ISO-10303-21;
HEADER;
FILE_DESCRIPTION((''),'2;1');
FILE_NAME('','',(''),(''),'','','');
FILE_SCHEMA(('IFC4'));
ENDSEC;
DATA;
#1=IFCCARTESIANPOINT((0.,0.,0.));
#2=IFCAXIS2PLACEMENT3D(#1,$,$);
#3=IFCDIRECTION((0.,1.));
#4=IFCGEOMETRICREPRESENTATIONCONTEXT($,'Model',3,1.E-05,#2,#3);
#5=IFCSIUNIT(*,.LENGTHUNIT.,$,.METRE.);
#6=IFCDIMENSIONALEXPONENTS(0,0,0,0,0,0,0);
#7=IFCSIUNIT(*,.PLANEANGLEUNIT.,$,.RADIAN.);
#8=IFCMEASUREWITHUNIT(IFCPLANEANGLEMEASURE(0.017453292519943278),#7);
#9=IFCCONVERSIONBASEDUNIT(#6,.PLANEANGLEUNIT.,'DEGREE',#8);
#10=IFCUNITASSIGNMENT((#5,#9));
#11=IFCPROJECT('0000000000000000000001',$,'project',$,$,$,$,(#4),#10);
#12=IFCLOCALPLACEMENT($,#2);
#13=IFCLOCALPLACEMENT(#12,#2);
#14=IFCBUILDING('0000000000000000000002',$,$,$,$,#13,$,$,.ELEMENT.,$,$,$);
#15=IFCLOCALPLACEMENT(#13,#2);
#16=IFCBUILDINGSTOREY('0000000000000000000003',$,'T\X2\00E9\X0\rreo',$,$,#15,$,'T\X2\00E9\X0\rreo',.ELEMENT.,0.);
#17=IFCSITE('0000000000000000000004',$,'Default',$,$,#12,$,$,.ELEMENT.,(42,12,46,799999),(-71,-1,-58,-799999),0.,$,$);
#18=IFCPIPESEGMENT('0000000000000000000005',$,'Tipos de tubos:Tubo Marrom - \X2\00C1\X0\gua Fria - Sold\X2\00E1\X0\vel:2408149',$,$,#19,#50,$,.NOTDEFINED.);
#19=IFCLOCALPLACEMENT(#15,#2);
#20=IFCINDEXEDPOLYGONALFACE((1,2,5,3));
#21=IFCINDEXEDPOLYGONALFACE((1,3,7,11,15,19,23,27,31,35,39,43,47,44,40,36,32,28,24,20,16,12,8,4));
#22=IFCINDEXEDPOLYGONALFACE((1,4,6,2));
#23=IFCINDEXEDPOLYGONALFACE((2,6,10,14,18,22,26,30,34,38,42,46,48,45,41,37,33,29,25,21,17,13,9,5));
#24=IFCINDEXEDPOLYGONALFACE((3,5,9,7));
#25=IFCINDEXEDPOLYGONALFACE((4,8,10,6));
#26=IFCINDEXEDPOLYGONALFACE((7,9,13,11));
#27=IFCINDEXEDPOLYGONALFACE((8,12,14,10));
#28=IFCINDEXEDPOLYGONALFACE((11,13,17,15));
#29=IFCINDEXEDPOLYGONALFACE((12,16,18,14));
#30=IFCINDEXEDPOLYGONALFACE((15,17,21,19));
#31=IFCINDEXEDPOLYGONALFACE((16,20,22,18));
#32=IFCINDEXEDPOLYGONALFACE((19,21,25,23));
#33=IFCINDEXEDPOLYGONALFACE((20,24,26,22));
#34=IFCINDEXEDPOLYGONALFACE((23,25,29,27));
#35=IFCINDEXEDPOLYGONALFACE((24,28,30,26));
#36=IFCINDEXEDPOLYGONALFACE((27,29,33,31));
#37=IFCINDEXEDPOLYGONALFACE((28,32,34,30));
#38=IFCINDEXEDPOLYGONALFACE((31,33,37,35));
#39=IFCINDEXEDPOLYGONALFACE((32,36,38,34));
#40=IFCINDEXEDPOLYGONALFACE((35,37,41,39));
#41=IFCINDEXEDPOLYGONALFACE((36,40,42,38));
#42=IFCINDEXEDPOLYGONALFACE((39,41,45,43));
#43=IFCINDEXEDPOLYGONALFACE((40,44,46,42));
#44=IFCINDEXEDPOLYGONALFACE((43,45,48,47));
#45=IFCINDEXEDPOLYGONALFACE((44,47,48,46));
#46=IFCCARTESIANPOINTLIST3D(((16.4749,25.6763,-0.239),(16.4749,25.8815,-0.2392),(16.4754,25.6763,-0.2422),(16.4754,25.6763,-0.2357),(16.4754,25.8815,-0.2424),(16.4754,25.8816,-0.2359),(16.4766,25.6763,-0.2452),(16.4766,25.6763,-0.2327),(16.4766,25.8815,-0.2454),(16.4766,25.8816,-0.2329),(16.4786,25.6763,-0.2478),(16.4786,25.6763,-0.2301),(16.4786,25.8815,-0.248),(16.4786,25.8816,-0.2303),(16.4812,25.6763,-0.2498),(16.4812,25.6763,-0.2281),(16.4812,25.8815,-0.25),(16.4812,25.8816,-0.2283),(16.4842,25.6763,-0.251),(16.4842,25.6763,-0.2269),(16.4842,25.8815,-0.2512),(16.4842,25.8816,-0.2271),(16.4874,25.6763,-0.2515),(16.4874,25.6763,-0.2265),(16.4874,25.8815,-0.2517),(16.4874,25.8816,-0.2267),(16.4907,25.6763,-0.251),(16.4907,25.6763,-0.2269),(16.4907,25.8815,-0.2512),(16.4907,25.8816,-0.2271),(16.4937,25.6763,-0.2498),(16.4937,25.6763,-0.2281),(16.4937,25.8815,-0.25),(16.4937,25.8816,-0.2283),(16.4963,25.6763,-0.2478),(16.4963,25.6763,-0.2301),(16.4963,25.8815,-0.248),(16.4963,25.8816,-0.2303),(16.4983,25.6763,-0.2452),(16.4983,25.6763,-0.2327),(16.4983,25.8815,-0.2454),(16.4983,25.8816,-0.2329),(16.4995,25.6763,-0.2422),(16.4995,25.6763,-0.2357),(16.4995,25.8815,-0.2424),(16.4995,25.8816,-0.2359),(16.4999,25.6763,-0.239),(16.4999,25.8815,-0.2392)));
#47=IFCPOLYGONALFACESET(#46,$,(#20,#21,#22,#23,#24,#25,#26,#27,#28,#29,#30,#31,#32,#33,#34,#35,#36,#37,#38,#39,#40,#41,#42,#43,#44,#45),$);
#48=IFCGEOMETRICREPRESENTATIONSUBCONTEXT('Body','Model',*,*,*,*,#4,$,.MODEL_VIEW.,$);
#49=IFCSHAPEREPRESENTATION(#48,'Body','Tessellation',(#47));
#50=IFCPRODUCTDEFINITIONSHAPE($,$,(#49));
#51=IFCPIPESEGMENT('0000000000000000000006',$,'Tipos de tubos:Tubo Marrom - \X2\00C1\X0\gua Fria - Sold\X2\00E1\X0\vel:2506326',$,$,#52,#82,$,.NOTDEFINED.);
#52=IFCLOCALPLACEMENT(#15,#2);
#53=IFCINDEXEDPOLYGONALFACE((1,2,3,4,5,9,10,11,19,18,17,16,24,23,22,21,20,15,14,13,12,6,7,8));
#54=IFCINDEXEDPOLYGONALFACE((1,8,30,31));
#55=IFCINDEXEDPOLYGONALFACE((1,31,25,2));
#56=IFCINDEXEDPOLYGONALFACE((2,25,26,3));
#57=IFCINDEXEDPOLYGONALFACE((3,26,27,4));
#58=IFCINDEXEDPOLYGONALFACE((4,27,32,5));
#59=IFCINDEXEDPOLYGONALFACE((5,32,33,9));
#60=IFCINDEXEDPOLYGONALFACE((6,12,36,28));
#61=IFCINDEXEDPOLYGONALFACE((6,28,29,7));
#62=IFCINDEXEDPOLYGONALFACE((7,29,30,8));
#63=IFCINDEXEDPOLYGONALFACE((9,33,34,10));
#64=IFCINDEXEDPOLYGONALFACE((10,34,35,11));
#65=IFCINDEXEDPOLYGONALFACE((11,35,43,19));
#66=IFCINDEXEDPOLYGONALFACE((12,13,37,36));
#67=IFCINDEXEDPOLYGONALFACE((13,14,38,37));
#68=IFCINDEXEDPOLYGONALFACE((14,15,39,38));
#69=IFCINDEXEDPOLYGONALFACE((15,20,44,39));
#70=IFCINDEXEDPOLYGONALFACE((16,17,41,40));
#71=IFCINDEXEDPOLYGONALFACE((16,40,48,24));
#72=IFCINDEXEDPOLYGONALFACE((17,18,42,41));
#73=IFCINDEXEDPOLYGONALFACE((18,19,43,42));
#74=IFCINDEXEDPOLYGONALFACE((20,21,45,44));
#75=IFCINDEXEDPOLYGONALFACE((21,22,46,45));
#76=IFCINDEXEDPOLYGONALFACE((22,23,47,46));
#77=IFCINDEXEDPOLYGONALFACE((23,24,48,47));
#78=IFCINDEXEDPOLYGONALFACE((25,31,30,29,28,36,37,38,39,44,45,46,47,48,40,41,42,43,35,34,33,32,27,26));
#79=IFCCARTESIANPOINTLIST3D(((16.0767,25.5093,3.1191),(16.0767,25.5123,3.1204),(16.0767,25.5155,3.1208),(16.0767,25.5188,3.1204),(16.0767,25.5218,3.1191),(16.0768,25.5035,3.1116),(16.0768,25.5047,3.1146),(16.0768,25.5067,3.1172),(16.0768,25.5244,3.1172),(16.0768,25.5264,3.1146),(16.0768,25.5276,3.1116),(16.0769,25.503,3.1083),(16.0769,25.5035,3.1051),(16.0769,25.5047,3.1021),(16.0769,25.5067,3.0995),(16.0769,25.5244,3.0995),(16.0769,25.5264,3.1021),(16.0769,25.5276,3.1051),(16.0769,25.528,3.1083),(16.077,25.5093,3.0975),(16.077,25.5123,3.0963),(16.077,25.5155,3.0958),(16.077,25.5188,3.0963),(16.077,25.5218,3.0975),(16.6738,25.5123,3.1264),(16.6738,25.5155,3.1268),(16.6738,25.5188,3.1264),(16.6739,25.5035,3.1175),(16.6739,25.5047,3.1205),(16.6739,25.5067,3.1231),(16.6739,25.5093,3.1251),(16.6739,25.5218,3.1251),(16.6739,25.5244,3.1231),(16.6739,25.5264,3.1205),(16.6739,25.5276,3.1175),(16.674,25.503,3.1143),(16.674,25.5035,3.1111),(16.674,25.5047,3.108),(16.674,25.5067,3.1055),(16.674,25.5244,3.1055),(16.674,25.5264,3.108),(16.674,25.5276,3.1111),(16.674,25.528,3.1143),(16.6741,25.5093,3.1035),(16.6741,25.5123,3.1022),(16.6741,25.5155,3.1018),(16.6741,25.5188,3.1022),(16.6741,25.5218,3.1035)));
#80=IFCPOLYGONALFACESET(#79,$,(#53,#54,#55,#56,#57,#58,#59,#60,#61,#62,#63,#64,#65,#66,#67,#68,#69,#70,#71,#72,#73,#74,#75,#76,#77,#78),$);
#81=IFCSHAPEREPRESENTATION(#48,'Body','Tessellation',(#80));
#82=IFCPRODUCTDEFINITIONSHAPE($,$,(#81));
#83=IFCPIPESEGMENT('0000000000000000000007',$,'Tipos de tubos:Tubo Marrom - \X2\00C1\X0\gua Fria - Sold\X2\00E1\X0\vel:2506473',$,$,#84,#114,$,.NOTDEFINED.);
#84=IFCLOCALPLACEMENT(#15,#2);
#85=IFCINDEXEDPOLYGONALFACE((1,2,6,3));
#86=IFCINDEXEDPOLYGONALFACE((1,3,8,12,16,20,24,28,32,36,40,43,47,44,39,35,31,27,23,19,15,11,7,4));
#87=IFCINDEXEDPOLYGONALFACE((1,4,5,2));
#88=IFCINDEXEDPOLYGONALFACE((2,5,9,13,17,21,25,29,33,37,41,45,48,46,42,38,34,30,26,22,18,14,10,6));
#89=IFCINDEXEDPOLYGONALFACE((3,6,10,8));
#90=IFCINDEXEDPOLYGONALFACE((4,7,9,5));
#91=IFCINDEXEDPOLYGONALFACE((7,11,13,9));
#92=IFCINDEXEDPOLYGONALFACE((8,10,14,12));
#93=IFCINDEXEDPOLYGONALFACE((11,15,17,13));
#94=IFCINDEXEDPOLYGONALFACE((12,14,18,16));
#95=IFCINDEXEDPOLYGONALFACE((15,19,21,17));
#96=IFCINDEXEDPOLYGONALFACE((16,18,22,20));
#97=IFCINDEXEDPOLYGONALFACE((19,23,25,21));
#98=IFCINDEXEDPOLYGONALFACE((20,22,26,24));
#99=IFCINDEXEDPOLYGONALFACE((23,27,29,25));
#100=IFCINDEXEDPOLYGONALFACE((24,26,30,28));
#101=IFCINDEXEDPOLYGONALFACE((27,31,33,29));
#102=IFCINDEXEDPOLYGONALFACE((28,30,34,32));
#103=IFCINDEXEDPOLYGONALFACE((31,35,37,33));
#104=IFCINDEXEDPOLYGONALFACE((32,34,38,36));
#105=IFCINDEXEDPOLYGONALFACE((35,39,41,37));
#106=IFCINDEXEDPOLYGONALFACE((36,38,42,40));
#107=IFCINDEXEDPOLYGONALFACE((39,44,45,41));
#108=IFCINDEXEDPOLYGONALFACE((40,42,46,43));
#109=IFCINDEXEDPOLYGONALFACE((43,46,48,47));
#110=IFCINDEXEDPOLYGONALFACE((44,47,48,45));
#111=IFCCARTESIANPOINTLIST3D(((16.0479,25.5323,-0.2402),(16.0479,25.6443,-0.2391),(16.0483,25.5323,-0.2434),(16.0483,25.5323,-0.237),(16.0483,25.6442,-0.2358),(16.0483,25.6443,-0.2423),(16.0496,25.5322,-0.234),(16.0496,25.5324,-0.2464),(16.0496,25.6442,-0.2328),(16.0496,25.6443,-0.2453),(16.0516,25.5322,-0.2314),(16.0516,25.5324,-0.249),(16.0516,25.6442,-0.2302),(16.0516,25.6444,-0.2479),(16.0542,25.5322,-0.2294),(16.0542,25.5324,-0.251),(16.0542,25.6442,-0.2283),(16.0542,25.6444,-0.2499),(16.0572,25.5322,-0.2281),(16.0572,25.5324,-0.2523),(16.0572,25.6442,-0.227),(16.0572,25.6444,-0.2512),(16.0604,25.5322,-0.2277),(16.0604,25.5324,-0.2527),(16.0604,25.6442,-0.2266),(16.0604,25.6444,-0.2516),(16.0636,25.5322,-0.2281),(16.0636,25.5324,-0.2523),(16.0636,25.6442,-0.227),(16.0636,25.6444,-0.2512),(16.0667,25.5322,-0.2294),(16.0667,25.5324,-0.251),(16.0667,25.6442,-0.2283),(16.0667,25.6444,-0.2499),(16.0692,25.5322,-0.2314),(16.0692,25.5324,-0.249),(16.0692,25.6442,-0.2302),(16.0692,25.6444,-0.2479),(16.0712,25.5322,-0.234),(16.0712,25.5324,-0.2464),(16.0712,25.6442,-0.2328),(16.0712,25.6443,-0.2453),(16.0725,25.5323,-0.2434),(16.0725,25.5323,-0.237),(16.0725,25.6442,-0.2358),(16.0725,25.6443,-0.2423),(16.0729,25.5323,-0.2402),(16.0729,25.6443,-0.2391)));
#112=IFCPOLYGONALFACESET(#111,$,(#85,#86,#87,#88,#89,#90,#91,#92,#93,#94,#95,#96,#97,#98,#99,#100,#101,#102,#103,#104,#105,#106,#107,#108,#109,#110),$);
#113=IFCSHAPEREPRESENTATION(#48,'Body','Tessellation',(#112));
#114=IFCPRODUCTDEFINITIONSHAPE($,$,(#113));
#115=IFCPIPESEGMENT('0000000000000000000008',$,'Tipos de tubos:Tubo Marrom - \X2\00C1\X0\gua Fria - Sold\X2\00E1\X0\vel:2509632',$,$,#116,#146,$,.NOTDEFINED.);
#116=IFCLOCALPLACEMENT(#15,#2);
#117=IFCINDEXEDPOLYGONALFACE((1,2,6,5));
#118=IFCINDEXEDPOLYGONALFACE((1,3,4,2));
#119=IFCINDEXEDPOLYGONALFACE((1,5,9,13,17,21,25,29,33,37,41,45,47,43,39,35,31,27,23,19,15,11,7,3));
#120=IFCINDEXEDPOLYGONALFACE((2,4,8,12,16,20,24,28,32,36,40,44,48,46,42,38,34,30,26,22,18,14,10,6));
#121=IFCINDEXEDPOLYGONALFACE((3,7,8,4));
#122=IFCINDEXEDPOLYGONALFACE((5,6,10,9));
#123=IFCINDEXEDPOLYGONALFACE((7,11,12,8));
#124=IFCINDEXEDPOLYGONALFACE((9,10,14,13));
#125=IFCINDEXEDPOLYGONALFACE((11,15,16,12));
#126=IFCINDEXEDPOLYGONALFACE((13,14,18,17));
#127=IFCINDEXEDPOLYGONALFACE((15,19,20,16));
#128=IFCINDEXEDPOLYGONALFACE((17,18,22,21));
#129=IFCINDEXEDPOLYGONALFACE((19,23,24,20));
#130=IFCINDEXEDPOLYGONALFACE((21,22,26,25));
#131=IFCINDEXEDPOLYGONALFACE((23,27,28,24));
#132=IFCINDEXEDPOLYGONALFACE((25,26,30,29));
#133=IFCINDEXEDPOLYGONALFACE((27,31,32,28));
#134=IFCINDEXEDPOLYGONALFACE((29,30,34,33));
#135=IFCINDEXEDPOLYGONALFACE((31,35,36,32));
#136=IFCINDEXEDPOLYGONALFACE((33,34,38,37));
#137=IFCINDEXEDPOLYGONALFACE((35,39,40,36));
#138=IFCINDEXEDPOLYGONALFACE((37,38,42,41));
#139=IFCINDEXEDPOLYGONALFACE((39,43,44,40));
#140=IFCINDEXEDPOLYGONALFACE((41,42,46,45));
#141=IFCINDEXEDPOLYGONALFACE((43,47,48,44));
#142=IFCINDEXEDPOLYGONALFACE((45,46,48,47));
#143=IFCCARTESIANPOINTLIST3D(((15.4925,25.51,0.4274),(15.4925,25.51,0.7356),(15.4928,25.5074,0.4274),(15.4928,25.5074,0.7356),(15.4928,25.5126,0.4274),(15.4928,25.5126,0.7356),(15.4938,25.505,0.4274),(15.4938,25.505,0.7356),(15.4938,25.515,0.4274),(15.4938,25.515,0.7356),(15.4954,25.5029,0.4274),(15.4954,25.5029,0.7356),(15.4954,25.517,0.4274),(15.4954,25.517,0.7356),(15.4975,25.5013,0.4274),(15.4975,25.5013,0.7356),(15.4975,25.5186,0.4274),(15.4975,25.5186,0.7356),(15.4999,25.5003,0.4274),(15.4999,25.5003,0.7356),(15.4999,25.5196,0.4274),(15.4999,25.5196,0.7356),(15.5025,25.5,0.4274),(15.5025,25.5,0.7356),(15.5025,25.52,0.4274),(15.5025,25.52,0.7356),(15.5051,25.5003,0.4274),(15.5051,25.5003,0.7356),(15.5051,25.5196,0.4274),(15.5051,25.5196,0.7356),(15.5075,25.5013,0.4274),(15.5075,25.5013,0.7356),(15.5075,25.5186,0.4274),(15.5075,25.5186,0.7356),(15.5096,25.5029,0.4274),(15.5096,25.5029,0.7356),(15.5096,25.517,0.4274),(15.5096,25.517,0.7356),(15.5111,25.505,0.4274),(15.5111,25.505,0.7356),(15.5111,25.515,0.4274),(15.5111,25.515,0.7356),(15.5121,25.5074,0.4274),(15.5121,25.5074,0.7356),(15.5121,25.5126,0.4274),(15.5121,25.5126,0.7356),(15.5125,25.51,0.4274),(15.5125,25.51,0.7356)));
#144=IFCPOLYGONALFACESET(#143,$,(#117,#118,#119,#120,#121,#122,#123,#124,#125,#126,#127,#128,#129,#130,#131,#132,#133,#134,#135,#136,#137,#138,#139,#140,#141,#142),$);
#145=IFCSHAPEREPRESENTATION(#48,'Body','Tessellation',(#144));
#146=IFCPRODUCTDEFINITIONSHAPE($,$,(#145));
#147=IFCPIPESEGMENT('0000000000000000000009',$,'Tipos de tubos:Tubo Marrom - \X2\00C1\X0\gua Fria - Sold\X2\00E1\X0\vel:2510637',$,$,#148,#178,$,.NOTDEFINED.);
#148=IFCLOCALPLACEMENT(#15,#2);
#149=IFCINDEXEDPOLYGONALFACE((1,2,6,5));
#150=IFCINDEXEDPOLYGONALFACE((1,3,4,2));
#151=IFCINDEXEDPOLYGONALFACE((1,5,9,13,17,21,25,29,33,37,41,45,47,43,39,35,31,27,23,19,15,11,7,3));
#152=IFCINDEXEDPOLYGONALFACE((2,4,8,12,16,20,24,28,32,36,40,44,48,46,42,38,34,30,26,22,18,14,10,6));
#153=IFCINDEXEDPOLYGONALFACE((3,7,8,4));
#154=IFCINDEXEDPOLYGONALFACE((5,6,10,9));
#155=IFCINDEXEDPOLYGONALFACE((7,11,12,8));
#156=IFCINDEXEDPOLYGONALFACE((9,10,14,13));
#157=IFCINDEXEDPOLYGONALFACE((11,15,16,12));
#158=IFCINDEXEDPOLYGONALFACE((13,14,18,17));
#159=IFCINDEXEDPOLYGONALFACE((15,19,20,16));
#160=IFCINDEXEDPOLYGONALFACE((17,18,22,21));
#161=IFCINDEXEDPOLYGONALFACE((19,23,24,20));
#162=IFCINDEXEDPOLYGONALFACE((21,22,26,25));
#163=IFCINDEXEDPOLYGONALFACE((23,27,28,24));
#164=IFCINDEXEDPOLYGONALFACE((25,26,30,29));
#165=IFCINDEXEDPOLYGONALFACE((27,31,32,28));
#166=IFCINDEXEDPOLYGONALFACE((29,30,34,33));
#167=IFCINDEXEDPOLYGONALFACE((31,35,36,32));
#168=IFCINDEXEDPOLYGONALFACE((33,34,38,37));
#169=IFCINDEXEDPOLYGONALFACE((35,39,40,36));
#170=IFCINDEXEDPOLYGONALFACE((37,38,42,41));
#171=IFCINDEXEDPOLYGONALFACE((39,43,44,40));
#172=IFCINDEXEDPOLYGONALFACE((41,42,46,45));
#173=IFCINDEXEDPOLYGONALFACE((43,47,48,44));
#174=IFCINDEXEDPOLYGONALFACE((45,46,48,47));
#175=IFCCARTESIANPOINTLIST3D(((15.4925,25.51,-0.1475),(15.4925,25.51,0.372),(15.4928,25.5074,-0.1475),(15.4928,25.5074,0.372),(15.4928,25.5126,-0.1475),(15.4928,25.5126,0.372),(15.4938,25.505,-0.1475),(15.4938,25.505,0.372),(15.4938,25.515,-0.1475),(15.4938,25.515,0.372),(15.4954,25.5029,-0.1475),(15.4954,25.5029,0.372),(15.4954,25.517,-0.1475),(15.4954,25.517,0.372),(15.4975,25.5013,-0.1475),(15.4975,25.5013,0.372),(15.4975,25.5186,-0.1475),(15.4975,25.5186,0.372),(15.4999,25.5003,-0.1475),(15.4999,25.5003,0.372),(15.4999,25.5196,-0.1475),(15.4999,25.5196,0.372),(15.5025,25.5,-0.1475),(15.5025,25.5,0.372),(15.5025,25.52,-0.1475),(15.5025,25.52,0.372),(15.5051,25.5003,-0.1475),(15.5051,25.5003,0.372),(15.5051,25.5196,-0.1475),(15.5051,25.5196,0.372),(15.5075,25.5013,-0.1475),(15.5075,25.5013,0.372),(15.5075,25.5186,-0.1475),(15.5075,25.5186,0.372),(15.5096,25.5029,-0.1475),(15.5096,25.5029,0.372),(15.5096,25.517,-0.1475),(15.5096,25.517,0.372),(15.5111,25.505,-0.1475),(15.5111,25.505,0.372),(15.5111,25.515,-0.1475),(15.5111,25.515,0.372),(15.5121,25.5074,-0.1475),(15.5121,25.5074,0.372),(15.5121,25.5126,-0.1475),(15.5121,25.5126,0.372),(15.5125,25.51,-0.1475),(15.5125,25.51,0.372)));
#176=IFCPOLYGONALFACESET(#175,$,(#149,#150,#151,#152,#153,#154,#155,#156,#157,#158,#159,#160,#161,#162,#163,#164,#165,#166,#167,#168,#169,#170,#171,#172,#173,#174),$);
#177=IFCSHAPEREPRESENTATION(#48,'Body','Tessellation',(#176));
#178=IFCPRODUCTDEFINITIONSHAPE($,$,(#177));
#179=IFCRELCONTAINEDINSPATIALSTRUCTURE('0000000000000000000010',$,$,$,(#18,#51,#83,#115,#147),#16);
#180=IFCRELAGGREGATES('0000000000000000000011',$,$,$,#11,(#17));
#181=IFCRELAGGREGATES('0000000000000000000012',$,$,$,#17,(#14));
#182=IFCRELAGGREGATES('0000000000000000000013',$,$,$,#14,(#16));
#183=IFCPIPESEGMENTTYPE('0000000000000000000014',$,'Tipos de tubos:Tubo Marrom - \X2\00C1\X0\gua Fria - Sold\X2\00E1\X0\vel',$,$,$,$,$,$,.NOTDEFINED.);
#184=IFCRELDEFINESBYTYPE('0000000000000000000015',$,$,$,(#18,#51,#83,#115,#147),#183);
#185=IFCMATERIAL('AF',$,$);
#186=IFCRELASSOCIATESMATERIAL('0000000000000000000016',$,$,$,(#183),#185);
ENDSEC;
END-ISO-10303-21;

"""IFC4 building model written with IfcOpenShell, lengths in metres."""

from ifc_helpers import new_model, entity, si_unit, converted_unit, direction, frame, origin, place, context, subcontext, project, spatial, arc, indexed_curve, outline, extrude, material, type_object, element, save


model = new_model("IFC4")

# Units and contexts
model_context = context("Model", 3, precision=1e-05, world=origin(), true_north=direction((0.0, 1.0)))
body_context = subcontext(model_context, "Body", "Model", "MODEL_VIEW")
ifc_project = project(units=[si_unit("LENGTHUNIT", "METRE"), converted_unit("PLANEANGLEUNIT", "DEGREE", entity("IfcPlaneAngleMeasure", 0.017453292519943278), si_unit("PLANEANGLEUNIT", "RADIAN"), dimensions=[0, 0, 0, 0, 0, 0, 0])], contexts=[model_context])

# Site, building, storey
site_placement = place(None, origin())
site = spatial("IfcSite", under=ifc_project, at=site_placement, Name="Default", CompositionType="ELEMENT", RefLatitude=(42, 12, 46, 799999), RefLongitude=(-71, -1, -58, -799999), RefElevation=0.0)
building_placement = place(site_placement, origin())
building = spatial("IfcBuilding", under=site, at=building_placement, CompositionType="ELEMENT")
storey_placement = place(building_placement, origin())
storey = spatial("IfcBuildingStorey", under=building, at=storey_placement, Name="Térreo", LongName="Térreo", CompositionType="ELEMENT", Elevation=0.0)

# Pipe segments
ifc_material_1 = material(Name="AF")
pipe_segment_type_1 = type_object("IfcPipeSegmentType", Name="Tipos de tubos:Tubo Marrom - Água Fria - Soldável", PredefinedType="NOTDEFINED", material=ifc_material_1)
pipe_segment_1_placement = place(storey_placement, origin())
element("IfcPipeSegment", 1, at=pipe_segment_1_placement, inside=storey, type_object=pipe_segment_type_1, Name="Tipos de tubos:Tubo Marrom - Água Fria - Soldável:2408149", PredefinedType="NOTDEFINED", context=body_context, shape_type="SweptSolid", body=[
    extrude(outline(indexed_curve([(0.0125, 0.0), (0.0088, 0.0088), (0.0, 0.0125), (-0.0088, 0.0088), (-0.0125, 0.0), (-0.0088, -0.0088), (0.0, -0.0125), (0.0088, -0.0088)], segments=[arc(1, 2, 3), arc(3, 4, 5), arc(5, 6, 7), arc(7, 8, 1)], self_intersect=False)), frame((16.4874, 25.8815, -0.2392), z_axis=(0.0, -0.999999, 0.00104), x_axis=(-1.0, 0.0, 0.0)), (0.0, 0.0, 1.0), 0.2053),
])
pipe_segment_2_placement = place(storey_placement, origin())
element("IfcPipeSegment", 2, at=pipe_segment_2_placement, inside=storey, type_object=pipe_segment_type_1, Name="Tipos de tubos:Tubo Marrom - Água Fria - Soldável:2506326", PredefinedType="NOTDEFINED", context=body_context, shape_type="SweptSolid", body=[
    extrude(outline(indexed_curve([(0.0125, 0.0), (0.0088, 0.0088), (0.0, 0.0125), (-0.0088, 0.0088), (-0.0125, 0.0), (-0.0088, -0.0088), (0.0, -0.0125), (0.0088, -0.0088)], segments=[arc(1, 2, 3), arc(3, 4, 5), arc(5, 6, 7), arc(7, 8, 1)], self_intersect=False)), frame((16.0769, 25.5155, 3.1083), z_axis=(0.99995, 0.0, 0.01), x_axis=(0.0, -1.0, 0.0)), (0.0, 0.0, 1.0), 0.5971),
])
pipe_segment_3_placement = place(storey_placement, origin())
element("IfcPipeSegment", 3, at=pipe_segment_3_placement, inside=storey, type_object=pipe_segment_type_1, Name="Tipos de tubos:Tubo Marrom - Água Fria - Soldável:2506473", PredefinedType="NOTDEFINED", context=body_context, shape_type="SweptSolid", body=[
    extrude(outline(indexed_curve([(0.0125, 0.0), (0.0088, 0.0088), (0.0, 0.0125), (-0.0088, 0.0088), (-0.0125, 0.0), (-0.0088, -0.0088), (0.0, -0.0125), (0.0088, -0.0088)], segments=[arc(1, 2, 3), arc(3, 4, 5), arc(5, 6, 7), arc(7, 8, 1)], self_intersect=False)), frame((16.0604, 25.5323, -0.2402), z_axis=(0.0, 0.99995, 0.01), x_axis=(1.0, 0.0, 0.0)), (0.0, 0.0, 1.0), 0.112),
])
pipe_segment_4_placement = place(storey_placement, origin())
element("IfcPipeSegment", 4, at=pipe_segment_4_placement, inside=storey, type_object=pipe_segment_type_1, Name="Tipos de tubos:Tubo Marrom - Água Fria - Soldável:2509632", PredefinedType="NOTDEFINED", context=body_context, shape_type="SweptSolid", body=[
    extrude(outline(indexed_curve([(0.01, 0.0), (0.0071, 0.0071), (0.0, 0.01), (-0.0071, 0.0071), (-0.01, 0.0), (-0.0071, -0.0071), (0.0, -0.01), (0.0071, -0.0071)], segments=[arc(1, 2, 3), arc(3, 4, 5), arc(5, 6, 7), arc(7, 8, 1)], self_intersect=False)), frame((15.5025, 25.51, 0.4274), z_axis=(0.0, 0.0, 1.0), x_axis=(-1.0, 0.0, 0.0)), (0.0, 0.0, 1.0), 0.3082),
])
pipe_segment_5_placement = place(storey_placement, origin())
element("IfcPipeSegment", 5, at=pipe_segment_5_placement, inside=storey, type_object=pipe_segment_type_1, Name="Tipos de tubos:Tubo Marrom - Água Fria - Soldável:2510637", PredefinedType="NOTDEFINED", context=body_context, shape_type="SweptSolid", body=[
    extrude(outline(indexed_curve([(0.01, 0.0), (0.0071, 0.0071), (0.0, 0.01), (-0.0071, 0.0071), (-0.01, 0.0), (-0.0071, -0.0071), (0.0, -0.01), (0.0071, -0.0071)], segments=[arc(1, 2, 3), arc(3, 4, 5), arc(5, 6, 7), arc(7, 8, 1)], self_intersect=False)), frame((15.5025, 25.51, -0.1475), z_axis=(0.0, 0.0, 1.0), x_axis=(-1.0, 0.0, 0.0)), (0.0, 0.0, 1.0), 0.5195),
])

save(model, "model.ifc")
